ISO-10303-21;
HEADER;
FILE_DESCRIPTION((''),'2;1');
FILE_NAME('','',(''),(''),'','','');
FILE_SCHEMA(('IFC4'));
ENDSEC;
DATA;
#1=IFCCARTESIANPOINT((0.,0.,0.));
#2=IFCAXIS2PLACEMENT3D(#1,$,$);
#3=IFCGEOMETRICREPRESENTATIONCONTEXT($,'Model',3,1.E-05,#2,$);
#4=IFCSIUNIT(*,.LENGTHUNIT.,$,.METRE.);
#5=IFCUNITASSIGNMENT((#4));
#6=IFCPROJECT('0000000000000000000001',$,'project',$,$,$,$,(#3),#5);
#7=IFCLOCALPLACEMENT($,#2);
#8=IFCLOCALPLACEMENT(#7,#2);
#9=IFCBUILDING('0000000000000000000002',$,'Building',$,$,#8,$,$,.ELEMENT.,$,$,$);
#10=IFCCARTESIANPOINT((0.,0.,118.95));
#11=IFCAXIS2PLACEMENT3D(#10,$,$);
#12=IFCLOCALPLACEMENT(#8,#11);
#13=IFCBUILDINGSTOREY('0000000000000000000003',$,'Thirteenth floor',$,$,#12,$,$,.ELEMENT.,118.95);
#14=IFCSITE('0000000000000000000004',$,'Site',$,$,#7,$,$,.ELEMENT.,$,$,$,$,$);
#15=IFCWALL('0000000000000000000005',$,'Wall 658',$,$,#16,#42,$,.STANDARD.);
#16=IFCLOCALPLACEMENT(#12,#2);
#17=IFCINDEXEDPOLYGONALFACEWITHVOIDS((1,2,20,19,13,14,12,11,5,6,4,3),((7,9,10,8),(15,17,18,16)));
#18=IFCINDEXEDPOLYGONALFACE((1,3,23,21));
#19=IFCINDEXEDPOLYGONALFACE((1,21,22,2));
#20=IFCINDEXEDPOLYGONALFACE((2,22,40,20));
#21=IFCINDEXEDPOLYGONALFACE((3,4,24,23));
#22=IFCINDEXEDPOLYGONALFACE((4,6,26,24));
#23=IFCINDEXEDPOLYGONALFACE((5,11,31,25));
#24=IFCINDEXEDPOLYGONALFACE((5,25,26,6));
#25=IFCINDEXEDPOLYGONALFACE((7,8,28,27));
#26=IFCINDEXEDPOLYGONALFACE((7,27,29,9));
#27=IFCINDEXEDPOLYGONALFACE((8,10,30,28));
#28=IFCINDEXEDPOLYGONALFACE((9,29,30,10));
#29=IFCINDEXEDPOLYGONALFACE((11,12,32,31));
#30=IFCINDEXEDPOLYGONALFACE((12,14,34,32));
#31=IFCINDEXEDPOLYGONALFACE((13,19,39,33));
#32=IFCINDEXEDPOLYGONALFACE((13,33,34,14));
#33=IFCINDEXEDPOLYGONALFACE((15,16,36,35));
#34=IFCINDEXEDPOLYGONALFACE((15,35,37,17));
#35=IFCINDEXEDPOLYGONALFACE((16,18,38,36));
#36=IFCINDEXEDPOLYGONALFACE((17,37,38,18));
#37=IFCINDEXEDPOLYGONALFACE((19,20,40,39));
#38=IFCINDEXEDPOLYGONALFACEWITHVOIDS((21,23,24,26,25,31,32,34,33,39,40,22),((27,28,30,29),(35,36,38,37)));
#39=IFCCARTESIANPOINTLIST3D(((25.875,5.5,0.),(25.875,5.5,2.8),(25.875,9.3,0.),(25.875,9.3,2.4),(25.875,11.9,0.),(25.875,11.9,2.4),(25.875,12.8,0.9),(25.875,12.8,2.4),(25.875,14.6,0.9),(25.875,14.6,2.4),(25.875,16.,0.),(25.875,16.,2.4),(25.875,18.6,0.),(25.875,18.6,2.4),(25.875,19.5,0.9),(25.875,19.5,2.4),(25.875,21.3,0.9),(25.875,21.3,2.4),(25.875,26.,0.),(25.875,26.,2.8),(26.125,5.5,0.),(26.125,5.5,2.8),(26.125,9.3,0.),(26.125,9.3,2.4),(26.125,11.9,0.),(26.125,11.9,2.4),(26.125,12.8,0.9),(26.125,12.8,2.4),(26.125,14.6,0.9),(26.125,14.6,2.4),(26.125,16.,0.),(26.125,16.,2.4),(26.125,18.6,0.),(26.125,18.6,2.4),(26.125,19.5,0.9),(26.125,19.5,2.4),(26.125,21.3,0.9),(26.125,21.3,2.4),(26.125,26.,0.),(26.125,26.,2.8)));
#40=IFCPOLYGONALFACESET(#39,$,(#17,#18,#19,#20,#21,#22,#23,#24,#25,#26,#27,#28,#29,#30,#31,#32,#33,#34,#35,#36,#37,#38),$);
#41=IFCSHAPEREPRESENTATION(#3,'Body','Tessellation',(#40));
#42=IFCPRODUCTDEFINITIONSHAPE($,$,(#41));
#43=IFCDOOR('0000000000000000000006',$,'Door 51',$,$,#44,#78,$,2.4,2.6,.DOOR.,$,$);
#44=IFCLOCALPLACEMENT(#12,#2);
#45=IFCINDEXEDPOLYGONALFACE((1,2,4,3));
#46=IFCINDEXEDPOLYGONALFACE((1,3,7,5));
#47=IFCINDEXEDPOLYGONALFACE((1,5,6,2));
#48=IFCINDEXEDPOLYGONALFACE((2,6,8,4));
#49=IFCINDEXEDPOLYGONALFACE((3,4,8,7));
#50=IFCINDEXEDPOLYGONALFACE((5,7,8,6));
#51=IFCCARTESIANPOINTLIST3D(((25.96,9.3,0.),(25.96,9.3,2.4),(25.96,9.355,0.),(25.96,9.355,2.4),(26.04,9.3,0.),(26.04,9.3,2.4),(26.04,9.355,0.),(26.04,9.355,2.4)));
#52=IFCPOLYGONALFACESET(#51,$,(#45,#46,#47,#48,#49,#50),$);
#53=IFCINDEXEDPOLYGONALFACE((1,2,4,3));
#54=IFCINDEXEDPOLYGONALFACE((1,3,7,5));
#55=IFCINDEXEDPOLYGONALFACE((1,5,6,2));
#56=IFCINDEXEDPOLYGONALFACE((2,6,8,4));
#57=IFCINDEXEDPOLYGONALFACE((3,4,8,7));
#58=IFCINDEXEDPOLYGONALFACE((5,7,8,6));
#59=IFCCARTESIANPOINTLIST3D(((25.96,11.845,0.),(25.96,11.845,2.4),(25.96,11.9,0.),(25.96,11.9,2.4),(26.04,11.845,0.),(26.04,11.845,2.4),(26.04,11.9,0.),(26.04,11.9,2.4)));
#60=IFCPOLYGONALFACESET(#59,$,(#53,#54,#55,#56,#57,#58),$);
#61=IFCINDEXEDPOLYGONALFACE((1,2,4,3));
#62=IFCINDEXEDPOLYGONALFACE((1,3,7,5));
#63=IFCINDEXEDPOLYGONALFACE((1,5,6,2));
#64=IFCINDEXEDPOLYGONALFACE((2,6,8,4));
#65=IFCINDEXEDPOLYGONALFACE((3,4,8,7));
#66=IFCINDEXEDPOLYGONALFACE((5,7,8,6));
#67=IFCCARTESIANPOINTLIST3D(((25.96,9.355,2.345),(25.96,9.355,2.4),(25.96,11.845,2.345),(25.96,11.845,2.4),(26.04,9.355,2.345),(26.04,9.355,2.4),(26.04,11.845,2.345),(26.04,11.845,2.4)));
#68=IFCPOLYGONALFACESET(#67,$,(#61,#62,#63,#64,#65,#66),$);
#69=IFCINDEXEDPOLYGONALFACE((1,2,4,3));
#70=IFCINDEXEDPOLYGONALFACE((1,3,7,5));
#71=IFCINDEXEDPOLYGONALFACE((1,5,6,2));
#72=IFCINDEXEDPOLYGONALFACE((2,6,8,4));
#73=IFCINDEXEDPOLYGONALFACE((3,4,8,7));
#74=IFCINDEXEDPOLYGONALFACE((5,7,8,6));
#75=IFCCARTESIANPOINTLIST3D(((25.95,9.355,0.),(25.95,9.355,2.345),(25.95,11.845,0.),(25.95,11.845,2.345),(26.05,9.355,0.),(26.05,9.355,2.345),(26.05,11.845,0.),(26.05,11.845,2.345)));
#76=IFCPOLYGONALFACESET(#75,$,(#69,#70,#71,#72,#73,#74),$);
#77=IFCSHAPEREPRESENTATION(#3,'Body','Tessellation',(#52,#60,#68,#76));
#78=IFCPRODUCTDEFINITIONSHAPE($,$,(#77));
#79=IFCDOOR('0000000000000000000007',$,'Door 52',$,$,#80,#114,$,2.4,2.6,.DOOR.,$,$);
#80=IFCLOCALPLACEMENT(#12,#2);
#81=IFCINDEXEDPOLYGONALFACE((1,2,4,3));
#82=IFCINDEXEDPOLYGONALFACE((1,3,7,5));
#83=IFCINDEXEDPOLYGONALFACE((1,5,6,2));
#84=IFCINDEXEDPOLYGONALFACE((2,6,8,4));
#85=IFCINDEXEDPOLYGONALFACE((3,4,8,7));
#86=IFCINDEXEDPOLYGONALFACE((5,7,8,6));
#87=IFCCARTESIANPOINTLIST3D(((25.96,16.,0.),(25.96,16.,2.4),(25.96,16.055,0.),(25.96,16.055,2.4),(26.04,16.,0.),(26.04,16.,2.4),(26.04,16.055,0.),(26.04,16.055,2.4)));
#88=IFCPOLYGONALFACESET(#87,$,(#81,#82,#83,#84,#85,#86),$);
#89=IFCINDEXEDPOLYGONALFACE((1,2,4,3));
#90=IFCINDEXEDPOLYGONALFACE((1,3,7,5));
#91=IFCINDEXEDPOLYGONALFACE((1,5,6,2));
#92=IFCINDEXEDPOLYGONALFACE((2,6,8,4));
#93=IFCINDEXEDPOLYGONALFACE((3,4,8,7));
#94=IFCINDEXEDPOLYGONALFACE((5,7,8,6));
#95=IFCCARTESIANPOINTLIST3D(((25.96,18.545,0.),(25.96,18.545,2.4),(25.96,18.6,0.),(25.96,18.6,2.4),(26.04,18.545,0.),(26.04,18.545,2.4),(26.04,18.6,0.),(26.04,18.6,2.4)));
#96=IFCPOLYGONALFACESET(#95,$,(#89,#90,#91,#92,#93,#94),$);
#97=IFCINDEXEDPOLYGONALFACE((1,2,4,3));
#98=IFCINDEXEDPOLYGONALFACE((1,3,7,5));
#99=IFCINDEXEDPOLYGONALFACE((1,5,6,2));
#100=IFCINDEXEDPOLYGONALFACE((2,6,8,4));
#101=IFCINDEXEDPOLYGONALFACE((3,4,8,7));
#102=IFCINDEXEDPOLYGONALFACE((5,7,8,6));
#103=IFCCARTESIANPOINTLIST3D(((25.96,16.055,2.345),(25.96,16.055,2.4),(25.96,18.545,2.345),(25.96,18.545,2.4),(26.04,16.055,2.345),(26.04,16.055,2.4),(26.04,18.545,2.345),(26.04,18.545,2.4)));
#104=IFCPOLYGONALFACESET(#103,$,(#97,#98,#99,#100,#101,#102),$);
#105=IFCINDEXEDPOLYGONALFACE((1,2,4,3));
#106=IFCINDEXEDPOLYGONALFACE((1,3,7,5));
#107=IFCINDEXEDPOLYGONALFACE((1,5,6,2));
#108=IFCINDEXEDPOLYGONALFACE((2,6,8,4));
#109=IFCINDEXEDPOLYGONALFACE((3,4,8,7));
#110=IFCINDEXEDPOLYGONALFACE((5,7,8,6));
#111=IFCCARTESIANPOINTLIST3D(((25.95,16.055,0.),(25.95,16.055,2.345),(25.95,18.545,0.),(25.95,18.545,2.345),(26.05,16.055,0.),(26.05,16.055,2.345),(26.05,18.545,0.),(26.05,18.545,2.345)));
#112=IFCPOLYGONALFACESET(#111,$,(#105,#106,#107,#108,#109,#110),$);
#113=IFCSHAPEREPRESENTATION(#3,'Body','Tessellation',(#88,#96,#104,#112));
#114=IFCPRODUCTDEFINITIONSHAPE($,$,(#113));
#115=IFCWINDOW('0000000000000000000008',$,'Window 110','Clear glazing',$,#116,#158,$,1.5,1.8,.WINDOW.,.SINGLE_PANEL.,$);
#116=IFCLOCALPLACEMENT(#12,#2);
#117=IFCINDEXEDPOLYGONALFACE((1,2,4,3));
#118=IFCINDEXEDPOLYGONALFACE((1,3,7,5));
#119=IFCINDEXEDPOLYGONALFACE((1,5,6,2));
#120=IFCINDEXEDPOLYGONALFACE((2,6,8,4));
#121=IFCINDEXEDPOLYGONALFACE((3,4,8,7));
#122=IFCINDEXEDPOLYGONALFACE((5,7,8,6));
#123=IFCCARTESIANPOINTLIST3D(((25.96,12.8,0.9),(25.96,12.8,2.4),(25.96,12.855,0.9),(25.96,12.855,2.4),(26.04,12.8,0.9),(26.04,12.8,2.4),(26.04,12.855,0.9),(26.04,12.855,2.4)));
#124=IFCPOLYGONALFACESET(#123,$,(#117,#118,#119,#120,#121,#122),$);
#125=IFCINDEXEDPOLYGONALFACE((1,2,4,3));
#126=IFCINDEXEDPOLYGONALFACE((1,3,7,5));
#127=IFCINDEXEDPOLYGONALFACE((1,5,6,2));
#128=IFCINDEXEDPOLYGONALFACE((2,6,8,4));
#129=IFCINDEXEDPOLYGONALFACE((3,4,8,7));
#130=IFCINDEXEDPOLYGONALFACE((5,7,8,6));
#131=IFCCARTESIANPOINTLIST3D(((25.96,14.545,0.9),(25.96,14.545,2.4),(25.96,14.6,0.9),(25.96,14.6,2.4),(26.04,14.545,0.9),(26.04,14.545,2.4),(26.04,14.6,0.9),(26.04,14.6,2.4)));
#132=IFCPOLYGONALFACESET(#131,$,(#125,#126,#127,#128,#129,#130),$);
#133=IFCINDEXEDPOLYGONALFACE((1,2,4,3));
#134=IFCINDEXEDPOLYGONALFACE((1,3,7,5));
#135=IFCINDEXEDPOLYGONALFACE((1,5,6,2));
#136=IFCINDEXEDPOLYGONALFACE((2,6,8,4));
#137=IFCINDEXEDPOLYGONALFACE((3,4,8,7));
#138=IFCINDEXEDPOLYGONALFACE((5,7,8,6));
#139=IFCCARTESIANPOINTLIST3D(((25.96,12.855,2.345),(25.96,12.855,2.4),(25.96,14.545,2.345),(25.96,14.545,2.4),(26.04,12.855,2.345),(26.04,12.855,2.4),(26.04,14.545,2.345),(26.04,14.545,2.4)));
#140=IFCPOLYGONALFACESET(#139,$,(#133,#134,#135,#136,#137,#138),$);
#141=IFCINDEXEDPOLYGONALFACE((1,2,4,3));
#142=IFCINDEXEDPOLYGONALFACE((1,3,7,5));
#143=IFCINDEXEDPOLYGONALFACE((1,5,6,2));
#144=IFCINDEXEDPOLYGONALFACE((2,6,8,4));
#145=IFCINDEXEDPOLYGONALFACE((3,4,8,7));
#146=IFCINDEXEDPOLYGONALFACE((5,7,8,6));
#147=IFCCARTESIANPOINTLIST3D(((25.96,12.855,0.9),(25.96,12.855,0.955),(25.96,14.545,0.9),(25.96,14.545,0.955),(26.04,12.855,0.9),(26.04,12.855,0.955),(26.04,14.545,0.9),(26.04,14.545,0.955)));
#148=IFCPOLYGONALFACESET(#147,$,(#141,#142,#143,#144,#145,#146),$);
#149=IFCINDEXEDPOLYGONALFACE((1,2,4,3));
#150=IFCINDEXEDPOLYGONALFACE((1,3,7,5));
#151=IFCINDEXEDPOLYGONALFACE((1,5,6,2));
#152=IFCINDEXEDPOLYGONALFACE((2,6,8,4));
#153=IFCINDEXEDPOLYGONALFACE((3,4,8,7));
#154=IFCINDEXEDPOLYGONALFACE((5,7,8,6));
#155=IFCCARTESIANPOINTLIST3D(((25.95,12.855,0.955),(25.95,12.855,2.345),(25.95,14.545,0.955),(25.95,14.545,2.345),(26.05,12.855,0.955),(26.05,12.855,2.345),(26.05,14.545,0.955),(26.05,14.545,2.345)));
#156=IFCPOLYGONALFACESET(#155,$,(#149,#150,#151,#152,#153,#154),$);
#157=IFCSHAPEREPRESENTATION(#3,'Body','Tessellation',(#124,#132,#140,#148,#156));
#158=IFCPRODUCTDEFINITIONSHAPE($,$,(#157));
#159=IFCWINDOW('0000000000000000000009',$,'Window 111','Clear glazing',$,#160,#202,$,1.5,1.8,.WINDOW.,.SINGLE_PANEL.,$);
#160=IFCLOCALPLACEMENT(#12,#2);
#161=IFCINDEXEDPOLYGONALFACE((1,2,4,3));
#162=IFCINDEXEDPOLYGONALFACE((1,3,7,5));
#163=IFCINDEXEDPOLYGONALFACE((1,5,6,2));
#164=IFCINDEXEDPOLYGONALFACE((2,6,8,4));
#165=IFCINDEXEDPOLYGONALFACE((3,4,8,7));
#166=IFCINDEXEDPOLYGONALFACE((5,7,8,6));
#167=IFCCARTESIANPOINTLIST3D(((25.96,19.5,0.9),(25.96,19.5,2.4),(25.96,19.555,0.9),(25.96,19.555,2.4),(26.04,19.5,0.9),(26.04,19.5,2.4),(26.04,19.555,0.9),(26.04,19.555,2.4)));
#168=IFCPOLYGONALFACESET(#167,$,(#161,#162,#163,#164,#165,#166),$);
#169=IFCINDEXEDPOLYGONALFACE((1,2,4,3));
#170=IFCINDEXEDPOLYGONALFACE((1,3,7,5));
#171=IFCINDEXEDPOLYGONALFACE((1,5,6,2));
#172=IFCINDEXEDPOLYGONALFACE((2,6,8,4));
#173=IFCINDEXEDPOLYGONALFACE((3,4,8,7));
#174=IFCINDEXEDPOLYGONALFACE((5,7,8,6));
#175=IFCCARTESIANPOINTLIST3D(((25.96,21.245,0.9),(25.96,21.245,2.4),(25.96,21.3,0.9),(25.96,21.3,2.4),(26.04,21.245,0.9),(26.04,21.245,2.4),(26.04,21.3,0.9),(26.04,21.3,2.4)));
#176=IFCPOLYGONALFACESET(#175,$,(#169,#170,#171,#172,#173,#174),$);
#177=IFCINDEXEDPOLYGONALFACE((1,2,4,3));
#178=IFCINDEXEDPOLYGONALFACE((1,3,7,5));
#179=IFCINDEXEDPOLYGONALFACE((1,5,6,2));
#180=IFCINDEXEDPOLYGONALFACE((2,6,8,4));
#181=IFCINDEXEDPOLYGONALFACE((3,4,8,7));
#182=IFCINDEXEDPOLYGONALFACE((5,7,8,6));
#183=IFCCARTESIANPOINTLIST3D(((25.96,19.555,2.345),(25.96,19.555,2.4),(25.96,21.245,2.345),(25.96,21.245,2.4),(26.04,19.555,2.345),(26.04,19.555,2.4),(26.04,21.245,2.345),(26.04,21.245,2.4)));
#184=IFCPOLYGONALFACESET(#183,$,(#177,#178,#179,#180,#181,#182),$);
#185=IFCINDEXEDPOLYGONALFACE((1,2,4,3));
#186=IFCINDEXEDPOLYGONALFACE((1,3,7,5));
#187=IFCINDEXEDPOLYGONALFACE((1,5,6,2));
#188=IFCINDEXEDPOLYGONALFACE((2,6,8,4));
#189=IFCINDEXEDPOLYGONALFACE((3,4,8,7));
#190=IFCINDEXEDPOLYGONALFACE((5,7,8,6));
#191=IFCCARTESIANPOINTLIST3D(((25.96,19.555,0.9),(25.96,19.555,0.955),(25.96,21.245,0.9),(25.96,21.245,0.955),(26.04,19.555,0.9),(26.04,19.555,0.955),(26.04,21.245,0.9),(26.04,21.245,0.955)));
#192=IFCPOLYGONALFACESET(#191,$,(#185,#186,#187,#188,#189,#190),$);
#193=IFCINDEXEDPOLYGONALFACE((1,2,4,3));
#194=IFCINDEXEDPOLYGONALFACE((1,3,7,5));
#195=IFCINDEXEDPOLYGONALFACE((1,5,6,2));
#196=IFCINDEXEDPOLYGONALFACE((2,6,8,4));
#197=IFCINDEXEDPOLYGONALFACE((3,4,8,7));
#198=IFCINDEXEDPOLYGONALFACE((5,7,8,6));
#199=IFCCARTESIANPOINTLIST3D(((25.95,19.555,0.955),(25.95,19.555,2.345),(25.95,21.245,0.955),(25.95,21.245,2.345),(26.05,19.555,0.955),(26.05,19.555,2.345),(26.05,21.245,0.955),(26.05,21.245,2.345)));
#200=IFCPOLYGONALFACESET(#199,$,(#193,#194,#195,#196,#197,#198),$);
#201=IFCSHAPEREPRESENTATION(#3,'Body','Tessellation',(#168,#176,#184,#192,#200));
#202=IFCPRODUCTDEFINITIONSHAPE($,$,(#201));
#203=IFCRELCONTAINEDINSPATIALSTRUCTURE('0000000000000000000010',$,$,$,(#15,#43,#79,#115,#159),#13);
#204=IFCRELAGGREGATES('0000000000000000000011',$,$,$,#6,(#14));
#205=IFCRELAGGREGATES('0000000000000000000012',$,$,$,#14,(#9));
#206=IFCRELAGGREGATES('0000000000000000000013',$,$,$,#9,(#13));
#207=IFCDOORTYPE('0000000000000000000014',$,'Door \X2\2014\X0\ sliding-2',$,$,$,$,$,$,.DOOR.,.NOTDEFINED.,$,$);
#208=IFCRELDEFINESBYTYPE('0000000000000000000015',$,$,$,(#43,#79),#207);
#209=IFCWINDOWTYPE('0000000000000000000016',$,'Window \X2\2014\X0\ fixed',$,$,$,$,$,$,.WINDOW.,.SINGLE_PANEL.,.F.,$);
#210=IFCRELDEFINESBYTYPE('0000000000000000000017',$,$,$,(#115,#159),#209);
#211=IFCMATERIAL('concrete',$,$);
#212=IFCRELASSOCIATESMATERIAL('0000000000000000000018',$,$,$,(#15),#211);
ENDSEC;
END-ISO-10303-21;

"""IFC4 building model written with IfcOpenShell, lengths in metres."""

from ifc_helpers import new_model, si_unit, frame, frame_2d, origin, place, context, project, spatial, rectangle, extrude, material, type_object, element, fill, save


model = new_model("IFC4")

# Units and contexts
model_context = context("Model", 3, precision=1e-05, world=origin())
ifc_project = project(units=[si_unit("LENGTHUNIT", "METRE")], contexts=[model_context])

# Site, building, storey
site_placement = place(None, origin())
site = spatial("IfcSite", under=ifc_project, at=site_placement, Name="Site", CompositionType="ELEMENT")
building_placement = place(site_placement, origin())
building = spatial("IfcBuilding", under=site, at=building_placement, Name="Building", CompositionType="ELEMENT")
storey_placement = place(building_placement, frame((0.0, 0.0, 118.95)))
storey = spatial("IfcBuildingStorey", under=building, at=storey_placement, Name="Thirteenth floor", CompositionType="ELEMENT", Elevation=118.95)

# Shared definitions
ifc_material = material(Name="concrete")

# Wall, openings, doors, windows
wall_1_placement = place(storey_placement, frame((26.0, 5.5, 0.0), z_axis=(0.0, 0.0, 1.0), x_axis=(0.0, 1.0, 0.0)))
wall_1 = element("IfcWall", 1, at=wall_1_placement, inside=storey, material=ifc_material, Name="Wall 658", PredefinedType="STANDARD", context=model_context, shape_type="SweptSolid", body=[
    extrude(rectangle(XDim=20.5, YDim=0.25, at=frame_2d((10.25, 0.0))), origin(), (0.0, 0.0, 1.0), 2.8),
])
opening_1_placement = place(storey_placement, frame((26.0, 9.3, 0.0), z_axis=(0.0, 0.0, 1.0), x_axis=(0.0, 1.0, 0.0)))
opening_1 = element("IfcOpeningElement", 2, at=opening_1_placement, cuts=wall_1, PredefinedType="OPENING", context=model_context, shape_type="SweptSolid", body=[
    extrude(rectangle(XDim=2.6, YDim=0.31, at=frame_2d((1.3, 0.0))), origin(), (0.0, 0.0, 1.0), 2.4),
])
opening_2_placement = place(storey_placement, frame((26.0, 12.8, 0.9), z_axis=(0.0, 0.0, 1.0), x_axis=(0.0, 1.0, 0.0)))
opening_2 = element("IfcOpeningElement", 3, at=opening_2_placement, cuts=wall_1, PredefinedType="OPENING", context=model_context, shape_type="SweptSolid", body=[
    extrude(rectangle(XDim=1.8, YDim=0.31, at=frame_2d((0.9, 0.0))), origin(), (0.0, 0.0, 1.0), 1.5),
])
opening_3_placement = place(storey_placement, frame((26.0, 16.0, 0.0), z_axis=(0.0, 0.0, 1.0), x_axis=(0.0, 1.0, 0.0)))
opening_3 = element("IfcOpeningElement", 4, at=opening_3_placement, cuts=wall_1, PredefinedType="OPENING", context=model_context, shape_type="SweptSolid", body=[
    extrude(rectangle(XDim=2.6, YDim=0.31, at=frame_2d((1.3, 0.0))), origin(), (0.0, 0.0, 1.0), 2.4),
])
opening_4_placement = place(storey_placement, frame((26.0, 19.5, 0.9), z_axis=(0.0, 0.0, 1.0), x_axis=(0.0, 1.0, 0.0)))
opening_4 = element("IfcOpeningElement", 5, at=opening_4_placement, cuts=wall_1, PredefinedType="OPENING", context=model_context, shape_type="SweptSolid", body=[
    extrude(rectangle(XDim=1.8, YDim=0.31, at=frame_2d((0.9, 0.0))), origin(), (0.0, 0.0, 1.0), 1.5),
])
door_type = type_object("IfcDoorType", Name="Door — sliding-2", PredefinedType="DOOR")
door_1_placement = place(storey_placement, frame((26.0, 9.3, 0.0), z_axis=(0.0, 0.0, 1.0), x_axis=(0.0, 1.0, 0.0)))
door_1 = element("IfcDoor", 6, at=door_1_placement, inside=storey, type_object=door_type, Name="Door 51", OverallHeight=2.4, OverallWidth=2.6, PredefinedType="DOOR", context=model_context, shape_type="SweptSolid", body=[
    extrude(rectangle(XDim=0.055, YDim=0.08, at=frame_2d((0.0275, 0.0))), origin(), (0.0, 0.0, 1.0), 2.4),
    extrude(rectangle(XDim=0.055, YDim=0.08, at=frame_2d((2.5725, 0.0))), origin(), (0.0, 0.0, 1.0), 2.4),
    extrude(rectangle(XDim=2.49, YDim=0.08, at=frame_2d((1.3, 0.0))), frame((0.0, 0.0, 2.345)), (0.0, 0.0, 1.0), 0.055),
    extrude(rectangle(XDim=2.49, YDim=0.1, at=frame_2d((1.3, 0.0))), origin(), (0.0, 0.0, 1.0), 2.345),
])
fill(opening_1, door_1)
door_2_placement = place(storey_placement, frame((26.0, 16.0, 0.0), z_axis=(0.0, 0.0, 1.0), x_axis=(0.0, 1.0, 0.0)))
door_2 = element("IfcDoor", 7, at=door_2_placement, inside=storey, type_object=door_type, Name="Door 52", OverallHeight=2.4, OverallWidth=2.6, PredefinedType="DOOR", context=model_context, shape_type="SweptSolid", body=[
    extrude(rectangle(XDim=0.055, YDim=0.08, at=frame_2d((0.0275, 0.0))), origin(), (0.0, 0.0, 1.0), 2.4),
    extrude(rectangle(XDim=0.055, YDim=0.08, at=frame_2d((2.5725, 0.0))), origin(), (0.0, 0.0, 1.0), 2.4),
    extrude(rectangle(XDim=2.49, YDim=0.08, at=frame_2d((1.3, 0.0))), frame((0.0, 0.0, 2.345)), (0.0, 0.0, 1.0), 0.055),
    extrude(rectangle(XDim=2.49, YDim=0.1, at=frame_2d((1.3, 0.0))), origin(), (0.0, 0.0, 1.0), 2.345),
])
fill(opening_3, door_2)
window_type = type_object("IfcWindowType", Name="Window — fixed", ParameterTakesPrecedence=False, PartitioningType="SINGLE_PANEL", PredefinedType="WINDOW")
window_1_placement = place(storey_placement, frame((26.0, 12.8, 0.9), z_axis=(0.0, 0.0, 1.0), x_axis=(0.0, 1.0, 0.0)))
window_1 = element("IfcWindow", 8, at=window_1_placement, inside=storey, type_object=window_type, Name="Window 110", Description="Clear glazing", OverallHeight=1.5, OverallWidth=1.8, PartitioningType="SINGLE_PANEL", PredefinedType="WINDOW", context=model_context, shape_type="SweptSolid", body=[
    extrude(rectangle(XDim=0.055, YDim=0.08, at=frame_2d((0.0275, 0.0))), origin(), (0.0, 0.0, 1.0), 1.5),
    extrude(rectangle(XDim=0.055, YDim=0.08, at=frame_2d((1.7725, 0.0))), origin(), (0.0, 0.0, 1.0), 1.5),
    extrude(rectangle(XDim=1.69, YDim=0.08, at=frame_2d((0.9, 0.0))), frame((0.0, 0.0, 1.445)), (0.0, 0.0, 1.0), 0.055),
    extrude(rectangle(XDim=1.69, YDim=0.08, at=frame_2d((0.9, 0.0))), origin(), (0.0, 0.0, 1.0), 0.055),
    extrude(rectangle(XDim=1.69, YDim=0.1, at=frame_2d((0.9, 0.0))), frame((0.0, 0.0, 0.055)), (0.0, 0.0, 1.0), 1.39),
])
fill(opening_2, window_1)
window_2_placement = place(storey_placement, frame((26.0, 19.5, 0.9), z_axis=(0.0, 0.0, 1.0), x_axis=(0.0, 1.0, 0.0)))
window_2 = element("IfcWindow", 9, at=window_2_placement, inside=storey, type_object=window_type, Name="Window 111", Description="Clear glazing", OverallHeight=1.5, OverallWidth=1.8, PartitioningType="SINGLE_PANEL", PredefinedType="WINDOW", context=model_context, shape_type="SweptSolid", body=[
    extrude(rectangle(XDim=0.055, YDim=0.08, at=frame_2d((0.0275, 0.0))), origin(), (0.0, 0.0, 1.0), 1.5),
    extrude(rectangle(XDim=0.055, YDim=0.08, at=frame_2d((1.7725, 0.0))), origin(), (0.0, 0.0, 1.0), 1.5),
    extrude(rectangle(XDim=1.69, YDim=0.08, at=frame_2d((0.9, 0.0))), frame((0.0, 0.0, 1.445)), (0.0, 0.0, 1.0), 0.055),
    extrude(rectangle(XDim=1.69, YDim=0.08, at=frame_2d((0.9, 0.0))), origin(), (0.0, 0.0, 1.0), 0.055),
    extrude(rectangle(XDim=1.69, YDim=0.1, at=frame_2d((0.9, 0.0))), frame((0.0, 0.0, 0.055)), (0.0, 0.0, 1.0), 1.39),
])
fill(opening_4, window_2)

save(model, "model.ifc")
